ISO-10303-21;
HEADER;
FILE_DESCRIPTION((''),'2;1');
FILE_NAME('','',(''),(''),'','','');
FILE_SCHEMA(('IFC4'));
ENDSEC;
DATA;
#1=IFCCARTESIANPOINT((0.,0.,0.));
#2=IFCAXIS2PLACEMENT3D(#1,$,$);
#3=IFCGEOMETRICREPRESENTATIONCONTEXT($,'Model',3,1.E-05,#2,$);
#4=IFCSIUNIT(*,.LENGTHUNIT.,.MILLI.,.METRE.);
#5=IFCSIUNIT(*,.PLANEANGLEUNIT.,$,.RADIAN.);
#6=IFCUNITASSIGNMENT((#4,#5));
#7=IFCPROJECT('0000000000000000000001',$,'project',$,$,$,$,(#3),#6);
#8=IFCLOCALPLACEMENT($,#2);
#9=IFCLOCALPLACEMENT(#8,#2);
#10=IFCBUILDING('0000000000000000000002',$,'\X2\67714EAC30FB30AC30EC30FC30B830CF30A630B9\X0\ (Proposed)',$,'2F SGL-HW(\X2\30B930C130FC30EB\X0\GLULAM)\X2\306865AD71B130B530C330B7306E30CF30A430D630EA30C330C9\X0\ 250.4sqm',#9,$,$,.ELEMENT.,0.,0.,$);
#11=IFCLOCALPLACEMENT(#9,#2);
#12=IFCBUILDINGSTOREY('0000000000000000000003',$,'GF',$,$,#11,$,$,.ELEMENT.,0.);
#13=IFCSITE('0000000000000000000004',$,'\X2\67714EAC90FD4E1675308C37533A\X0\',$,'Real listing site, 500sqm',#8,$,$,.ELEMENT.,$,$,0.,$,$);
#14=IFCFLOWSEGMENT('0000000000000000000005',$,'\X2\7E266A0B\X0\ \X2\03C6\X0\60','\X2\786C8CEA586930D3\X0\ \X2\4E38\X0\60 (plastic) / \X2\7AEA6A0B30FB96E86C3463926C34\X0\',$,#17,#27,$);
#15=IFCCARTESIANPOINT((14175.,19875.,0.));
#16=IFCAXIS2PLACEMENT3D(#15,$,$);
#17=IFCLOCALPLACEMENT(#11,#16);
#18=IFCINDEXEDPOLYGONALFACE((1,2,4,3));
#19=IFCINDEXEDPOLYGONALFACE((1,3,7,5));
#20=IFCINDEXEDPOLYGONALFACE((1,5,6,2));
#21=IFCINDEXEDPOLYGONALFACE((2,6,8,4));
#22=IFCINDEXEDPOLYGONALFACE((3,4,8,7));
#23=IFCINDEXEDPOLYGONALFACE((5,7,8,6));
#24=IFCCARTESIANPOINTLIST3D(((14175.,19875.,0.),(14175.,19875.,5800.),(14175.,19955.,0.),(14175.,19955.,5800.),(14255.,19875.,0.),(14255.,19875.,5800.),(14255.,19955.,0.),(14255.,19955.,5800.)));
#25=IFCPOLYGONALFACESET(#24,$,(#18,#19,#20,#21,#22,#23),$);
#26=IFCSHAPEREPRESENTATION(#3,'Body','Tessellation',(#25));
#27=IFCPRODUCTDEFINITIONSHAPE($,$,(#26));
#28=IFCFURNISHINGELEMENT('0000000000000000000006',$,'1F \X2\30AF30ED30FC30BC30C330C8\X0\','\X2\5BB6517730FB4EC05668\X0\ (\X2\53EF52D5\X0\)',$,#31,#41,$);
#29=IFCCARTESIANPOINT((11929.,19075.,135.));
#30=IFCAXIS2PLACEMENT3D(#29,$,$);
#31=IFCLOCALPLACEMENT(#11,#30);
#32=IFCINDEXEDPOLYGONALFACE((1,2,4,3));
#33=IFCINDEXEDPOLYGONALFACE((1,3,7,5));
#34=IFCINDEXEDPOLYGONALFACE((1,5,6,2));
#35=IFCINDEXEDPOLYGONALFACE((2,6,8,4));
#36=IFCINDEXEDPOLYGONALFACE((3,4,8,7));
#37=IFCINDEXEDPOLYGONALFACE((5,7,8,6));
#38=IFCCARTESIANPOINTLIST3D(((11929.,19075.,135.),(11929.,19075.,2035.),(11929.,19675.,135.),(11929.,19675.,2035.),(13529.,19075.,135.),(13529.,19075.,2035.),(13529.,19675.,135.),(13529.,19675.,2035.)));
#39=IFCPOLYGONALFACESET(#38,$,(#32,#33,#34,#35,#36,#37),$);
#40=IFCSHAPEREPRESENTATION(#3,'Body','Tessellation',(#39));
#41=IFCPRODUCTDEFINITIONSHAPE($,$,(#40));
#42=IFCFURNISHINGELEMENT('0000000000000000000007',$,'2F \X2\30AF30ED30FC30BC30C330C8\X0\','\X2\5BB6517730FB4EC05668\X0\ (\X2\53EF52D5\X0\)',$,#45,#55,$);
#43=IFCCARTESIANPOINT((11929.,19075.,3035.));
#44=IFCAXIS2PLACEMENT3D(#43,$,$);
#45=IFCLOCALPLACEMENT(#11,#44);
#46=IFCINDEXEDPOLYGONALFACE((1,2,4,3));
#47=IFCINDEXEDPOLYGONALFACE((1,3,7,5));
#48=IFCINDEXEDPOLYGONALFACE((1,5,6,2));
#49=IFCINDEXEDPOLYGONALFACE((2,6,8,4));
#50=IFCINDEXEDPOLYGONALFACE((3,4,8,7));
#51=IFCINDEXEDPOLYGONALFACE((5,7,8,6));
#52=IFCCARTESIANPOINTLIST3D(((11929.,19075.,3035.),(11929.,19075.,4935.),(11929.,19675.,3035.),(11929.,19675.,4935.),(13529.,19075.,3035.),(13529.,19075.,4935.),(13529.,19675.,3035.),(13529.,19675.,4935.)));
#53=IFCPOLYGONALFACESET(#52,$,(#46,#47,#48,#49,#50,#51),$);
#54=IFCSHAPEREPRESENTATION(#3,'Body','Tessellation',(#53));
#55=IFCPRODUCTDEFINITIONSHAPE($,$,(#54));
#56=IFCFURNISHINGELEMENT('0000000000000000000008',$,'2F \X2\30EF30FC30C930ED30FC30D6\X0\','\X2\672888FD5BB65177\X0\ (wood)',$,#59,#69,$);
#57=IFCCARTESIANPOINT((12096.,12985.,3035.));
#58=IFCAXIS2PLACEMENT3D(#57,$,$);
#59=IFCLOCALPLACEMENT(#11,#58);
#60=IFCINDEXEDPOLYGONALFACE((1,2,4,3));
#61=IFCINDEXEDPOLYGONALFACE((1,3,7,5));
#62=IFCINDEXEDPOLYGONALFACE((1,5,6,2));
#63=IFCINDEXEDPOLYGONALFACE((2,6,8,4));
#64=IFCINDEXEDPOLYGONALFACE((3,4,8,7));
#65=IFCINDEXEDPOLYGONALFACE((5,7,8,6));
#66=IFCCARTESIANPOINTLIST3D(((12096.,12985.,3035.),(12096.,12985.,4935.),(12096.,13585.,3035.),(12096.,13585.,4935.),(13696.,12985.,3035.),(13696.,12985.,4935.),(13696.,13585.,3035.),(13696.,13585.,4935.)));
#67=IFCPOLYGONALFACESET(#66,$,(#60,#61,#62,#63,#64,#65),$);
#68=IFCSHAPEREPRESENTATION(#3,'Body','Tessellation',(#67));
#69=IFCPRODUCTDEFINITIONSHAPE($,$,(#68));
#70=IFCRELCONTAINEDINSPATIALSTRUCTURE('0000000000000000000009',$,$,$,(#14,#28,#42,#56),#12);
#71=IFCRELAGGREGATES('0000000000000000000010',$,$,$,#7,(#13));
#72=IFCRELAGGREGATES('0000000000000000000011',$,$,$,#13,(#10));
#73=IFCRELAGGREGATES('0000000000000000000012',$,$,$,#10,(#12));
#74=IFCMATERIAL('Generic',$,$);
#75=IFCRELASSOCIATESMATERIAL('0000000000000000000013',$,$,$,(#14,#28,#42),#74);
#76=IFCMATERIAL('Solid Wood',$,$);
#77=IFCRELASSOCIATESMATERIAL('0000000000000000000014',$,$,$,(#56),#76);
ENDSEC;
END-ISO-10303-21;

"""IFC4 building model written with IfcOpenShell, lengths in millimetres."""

from ifc_helpers import new_model, si_unit, frame, frame_2d, origin, place, context, project, spatial, rectangle, extrude, material, element, save


model = new_model("IFC4")

# Units and contexts
model_context = context("Model", 3, precision=1e-05, world=origin())
ifc_project = project(units=[si_unit("LENGTHUNIT", "METRE", prefix="MILLI"), si_unit("PLANEANGLEUNIT", "RADIAN")], contexts=[model_context])

# Site, building, storey
site_placement = place(None, origin())
site = spatial("IfcSite", under=ifc_project, at=site_placement, Name="東京都世田谷区", ObjectType="Real listing site, 500sqm", CompositionType="ELEMENT", RefElevation=0.0)
building_placement = place(site_placement, origin())
building = spatial("IfcBuilding", under=site, at=building_placement, Name="東京・ガレージハウス (Proposed)", ObjectType="2F SGL-HW(スチールGLULAM)と断熱サッシのハイブリッド 250.4sqm", CompositionType="ELEMENT", ElevationOfRefHeight=0.0, ElevationOfTerrain=0.0)
storey_placement = place(building_placement, origin())
storey = spatial("IfcBuildingStorey", under=building, at=storey_placement, Name="GF", CompositionType="ELEMENT", Elevation=0.0)

# Shared definitions
ifc_material_1 = material(Name="Solid Wood")

# Shared definitions
ifc_material_2 = material(Name="Generic")

# Flow segment
flow_segment_placement = place(storey_placement, frame((14175.0, 19875.0, 0.0)))
element("IfcFlowSegment", 1, at=flow_segment_placement, inside=storey, material=ifc_material_2, Name="縦樋 φ60", Description="硬質塩ビ 丸60 (plastic) / 竪樋・雨水排水", context=model_context, shape_type="SweptSolid", body=[
    extrude(rectangle(XDim=80.0, YDim=80.0, at=frame_2d((40.0, 40.0))), frame((14175.0, 19875.0, 0.0)), (0.0, 0.0, 1.0), 5800.0),
])

# Furnishing elements
furnishing_1_placement = place(storey_placement, frame((11929.0, 19075.0, 135.0)))
element("IfcFurnishingElement", 2, at=furnishing_1_placement, inside=storey, material=ifc_material_2, Name="1F クローゼット", Description="家具・什器 (可動)", context=model_context, shape_type="SweptSolid", body=[
    extrude(rectangle(XDim=1600.0, YDim=600.0, at=frame_2d((800.0, 300.0))), frame((11929.0, 19075.0, 135.0)), (0.0, 0.0, 1.0), 1900.0),
])
furnishing_2_placement = place(storey_placement, frame((11929.0, 19075.0, 3035.0)))
element("IfcFurnishingElement", 3, at=furnishing_2_placement, inside=storey, material=ifc_material_2, Name="2F クローゼット", Description="家具・什器 (可動)", context=model_context, shape_type="SweptSolid", body=[
    extrude(rectangle(XDim=1600.0, YDim=600.0, at=frame_2d((800.0, 300.0))), frame((11929.0, 19075.0, 3035.0)), (0.0, 0.0, 1.0), 1900.0),
])
furnishing_3_placement = place(storey_placement, frame((12096.0, 12985.0, 3035.0)))
element("IfcFurnishingElement", 4, at=furnishing_3_placement, inside=storey, material=ifc_material_1, Name="2F ワードローブ", Description="木製家具 (wood)", context=model_context, shape_type="SweptSolid", body=[
    extrude(rectangle(XDim=1600.0, YDim=600.0, at=frame_2d((800.0, 300.0))), frame((12096.0, 12985.0, 3035.0)), (0.0, 0.0, 1.0), 1900.0),
])

save(model, "model.ifc")
